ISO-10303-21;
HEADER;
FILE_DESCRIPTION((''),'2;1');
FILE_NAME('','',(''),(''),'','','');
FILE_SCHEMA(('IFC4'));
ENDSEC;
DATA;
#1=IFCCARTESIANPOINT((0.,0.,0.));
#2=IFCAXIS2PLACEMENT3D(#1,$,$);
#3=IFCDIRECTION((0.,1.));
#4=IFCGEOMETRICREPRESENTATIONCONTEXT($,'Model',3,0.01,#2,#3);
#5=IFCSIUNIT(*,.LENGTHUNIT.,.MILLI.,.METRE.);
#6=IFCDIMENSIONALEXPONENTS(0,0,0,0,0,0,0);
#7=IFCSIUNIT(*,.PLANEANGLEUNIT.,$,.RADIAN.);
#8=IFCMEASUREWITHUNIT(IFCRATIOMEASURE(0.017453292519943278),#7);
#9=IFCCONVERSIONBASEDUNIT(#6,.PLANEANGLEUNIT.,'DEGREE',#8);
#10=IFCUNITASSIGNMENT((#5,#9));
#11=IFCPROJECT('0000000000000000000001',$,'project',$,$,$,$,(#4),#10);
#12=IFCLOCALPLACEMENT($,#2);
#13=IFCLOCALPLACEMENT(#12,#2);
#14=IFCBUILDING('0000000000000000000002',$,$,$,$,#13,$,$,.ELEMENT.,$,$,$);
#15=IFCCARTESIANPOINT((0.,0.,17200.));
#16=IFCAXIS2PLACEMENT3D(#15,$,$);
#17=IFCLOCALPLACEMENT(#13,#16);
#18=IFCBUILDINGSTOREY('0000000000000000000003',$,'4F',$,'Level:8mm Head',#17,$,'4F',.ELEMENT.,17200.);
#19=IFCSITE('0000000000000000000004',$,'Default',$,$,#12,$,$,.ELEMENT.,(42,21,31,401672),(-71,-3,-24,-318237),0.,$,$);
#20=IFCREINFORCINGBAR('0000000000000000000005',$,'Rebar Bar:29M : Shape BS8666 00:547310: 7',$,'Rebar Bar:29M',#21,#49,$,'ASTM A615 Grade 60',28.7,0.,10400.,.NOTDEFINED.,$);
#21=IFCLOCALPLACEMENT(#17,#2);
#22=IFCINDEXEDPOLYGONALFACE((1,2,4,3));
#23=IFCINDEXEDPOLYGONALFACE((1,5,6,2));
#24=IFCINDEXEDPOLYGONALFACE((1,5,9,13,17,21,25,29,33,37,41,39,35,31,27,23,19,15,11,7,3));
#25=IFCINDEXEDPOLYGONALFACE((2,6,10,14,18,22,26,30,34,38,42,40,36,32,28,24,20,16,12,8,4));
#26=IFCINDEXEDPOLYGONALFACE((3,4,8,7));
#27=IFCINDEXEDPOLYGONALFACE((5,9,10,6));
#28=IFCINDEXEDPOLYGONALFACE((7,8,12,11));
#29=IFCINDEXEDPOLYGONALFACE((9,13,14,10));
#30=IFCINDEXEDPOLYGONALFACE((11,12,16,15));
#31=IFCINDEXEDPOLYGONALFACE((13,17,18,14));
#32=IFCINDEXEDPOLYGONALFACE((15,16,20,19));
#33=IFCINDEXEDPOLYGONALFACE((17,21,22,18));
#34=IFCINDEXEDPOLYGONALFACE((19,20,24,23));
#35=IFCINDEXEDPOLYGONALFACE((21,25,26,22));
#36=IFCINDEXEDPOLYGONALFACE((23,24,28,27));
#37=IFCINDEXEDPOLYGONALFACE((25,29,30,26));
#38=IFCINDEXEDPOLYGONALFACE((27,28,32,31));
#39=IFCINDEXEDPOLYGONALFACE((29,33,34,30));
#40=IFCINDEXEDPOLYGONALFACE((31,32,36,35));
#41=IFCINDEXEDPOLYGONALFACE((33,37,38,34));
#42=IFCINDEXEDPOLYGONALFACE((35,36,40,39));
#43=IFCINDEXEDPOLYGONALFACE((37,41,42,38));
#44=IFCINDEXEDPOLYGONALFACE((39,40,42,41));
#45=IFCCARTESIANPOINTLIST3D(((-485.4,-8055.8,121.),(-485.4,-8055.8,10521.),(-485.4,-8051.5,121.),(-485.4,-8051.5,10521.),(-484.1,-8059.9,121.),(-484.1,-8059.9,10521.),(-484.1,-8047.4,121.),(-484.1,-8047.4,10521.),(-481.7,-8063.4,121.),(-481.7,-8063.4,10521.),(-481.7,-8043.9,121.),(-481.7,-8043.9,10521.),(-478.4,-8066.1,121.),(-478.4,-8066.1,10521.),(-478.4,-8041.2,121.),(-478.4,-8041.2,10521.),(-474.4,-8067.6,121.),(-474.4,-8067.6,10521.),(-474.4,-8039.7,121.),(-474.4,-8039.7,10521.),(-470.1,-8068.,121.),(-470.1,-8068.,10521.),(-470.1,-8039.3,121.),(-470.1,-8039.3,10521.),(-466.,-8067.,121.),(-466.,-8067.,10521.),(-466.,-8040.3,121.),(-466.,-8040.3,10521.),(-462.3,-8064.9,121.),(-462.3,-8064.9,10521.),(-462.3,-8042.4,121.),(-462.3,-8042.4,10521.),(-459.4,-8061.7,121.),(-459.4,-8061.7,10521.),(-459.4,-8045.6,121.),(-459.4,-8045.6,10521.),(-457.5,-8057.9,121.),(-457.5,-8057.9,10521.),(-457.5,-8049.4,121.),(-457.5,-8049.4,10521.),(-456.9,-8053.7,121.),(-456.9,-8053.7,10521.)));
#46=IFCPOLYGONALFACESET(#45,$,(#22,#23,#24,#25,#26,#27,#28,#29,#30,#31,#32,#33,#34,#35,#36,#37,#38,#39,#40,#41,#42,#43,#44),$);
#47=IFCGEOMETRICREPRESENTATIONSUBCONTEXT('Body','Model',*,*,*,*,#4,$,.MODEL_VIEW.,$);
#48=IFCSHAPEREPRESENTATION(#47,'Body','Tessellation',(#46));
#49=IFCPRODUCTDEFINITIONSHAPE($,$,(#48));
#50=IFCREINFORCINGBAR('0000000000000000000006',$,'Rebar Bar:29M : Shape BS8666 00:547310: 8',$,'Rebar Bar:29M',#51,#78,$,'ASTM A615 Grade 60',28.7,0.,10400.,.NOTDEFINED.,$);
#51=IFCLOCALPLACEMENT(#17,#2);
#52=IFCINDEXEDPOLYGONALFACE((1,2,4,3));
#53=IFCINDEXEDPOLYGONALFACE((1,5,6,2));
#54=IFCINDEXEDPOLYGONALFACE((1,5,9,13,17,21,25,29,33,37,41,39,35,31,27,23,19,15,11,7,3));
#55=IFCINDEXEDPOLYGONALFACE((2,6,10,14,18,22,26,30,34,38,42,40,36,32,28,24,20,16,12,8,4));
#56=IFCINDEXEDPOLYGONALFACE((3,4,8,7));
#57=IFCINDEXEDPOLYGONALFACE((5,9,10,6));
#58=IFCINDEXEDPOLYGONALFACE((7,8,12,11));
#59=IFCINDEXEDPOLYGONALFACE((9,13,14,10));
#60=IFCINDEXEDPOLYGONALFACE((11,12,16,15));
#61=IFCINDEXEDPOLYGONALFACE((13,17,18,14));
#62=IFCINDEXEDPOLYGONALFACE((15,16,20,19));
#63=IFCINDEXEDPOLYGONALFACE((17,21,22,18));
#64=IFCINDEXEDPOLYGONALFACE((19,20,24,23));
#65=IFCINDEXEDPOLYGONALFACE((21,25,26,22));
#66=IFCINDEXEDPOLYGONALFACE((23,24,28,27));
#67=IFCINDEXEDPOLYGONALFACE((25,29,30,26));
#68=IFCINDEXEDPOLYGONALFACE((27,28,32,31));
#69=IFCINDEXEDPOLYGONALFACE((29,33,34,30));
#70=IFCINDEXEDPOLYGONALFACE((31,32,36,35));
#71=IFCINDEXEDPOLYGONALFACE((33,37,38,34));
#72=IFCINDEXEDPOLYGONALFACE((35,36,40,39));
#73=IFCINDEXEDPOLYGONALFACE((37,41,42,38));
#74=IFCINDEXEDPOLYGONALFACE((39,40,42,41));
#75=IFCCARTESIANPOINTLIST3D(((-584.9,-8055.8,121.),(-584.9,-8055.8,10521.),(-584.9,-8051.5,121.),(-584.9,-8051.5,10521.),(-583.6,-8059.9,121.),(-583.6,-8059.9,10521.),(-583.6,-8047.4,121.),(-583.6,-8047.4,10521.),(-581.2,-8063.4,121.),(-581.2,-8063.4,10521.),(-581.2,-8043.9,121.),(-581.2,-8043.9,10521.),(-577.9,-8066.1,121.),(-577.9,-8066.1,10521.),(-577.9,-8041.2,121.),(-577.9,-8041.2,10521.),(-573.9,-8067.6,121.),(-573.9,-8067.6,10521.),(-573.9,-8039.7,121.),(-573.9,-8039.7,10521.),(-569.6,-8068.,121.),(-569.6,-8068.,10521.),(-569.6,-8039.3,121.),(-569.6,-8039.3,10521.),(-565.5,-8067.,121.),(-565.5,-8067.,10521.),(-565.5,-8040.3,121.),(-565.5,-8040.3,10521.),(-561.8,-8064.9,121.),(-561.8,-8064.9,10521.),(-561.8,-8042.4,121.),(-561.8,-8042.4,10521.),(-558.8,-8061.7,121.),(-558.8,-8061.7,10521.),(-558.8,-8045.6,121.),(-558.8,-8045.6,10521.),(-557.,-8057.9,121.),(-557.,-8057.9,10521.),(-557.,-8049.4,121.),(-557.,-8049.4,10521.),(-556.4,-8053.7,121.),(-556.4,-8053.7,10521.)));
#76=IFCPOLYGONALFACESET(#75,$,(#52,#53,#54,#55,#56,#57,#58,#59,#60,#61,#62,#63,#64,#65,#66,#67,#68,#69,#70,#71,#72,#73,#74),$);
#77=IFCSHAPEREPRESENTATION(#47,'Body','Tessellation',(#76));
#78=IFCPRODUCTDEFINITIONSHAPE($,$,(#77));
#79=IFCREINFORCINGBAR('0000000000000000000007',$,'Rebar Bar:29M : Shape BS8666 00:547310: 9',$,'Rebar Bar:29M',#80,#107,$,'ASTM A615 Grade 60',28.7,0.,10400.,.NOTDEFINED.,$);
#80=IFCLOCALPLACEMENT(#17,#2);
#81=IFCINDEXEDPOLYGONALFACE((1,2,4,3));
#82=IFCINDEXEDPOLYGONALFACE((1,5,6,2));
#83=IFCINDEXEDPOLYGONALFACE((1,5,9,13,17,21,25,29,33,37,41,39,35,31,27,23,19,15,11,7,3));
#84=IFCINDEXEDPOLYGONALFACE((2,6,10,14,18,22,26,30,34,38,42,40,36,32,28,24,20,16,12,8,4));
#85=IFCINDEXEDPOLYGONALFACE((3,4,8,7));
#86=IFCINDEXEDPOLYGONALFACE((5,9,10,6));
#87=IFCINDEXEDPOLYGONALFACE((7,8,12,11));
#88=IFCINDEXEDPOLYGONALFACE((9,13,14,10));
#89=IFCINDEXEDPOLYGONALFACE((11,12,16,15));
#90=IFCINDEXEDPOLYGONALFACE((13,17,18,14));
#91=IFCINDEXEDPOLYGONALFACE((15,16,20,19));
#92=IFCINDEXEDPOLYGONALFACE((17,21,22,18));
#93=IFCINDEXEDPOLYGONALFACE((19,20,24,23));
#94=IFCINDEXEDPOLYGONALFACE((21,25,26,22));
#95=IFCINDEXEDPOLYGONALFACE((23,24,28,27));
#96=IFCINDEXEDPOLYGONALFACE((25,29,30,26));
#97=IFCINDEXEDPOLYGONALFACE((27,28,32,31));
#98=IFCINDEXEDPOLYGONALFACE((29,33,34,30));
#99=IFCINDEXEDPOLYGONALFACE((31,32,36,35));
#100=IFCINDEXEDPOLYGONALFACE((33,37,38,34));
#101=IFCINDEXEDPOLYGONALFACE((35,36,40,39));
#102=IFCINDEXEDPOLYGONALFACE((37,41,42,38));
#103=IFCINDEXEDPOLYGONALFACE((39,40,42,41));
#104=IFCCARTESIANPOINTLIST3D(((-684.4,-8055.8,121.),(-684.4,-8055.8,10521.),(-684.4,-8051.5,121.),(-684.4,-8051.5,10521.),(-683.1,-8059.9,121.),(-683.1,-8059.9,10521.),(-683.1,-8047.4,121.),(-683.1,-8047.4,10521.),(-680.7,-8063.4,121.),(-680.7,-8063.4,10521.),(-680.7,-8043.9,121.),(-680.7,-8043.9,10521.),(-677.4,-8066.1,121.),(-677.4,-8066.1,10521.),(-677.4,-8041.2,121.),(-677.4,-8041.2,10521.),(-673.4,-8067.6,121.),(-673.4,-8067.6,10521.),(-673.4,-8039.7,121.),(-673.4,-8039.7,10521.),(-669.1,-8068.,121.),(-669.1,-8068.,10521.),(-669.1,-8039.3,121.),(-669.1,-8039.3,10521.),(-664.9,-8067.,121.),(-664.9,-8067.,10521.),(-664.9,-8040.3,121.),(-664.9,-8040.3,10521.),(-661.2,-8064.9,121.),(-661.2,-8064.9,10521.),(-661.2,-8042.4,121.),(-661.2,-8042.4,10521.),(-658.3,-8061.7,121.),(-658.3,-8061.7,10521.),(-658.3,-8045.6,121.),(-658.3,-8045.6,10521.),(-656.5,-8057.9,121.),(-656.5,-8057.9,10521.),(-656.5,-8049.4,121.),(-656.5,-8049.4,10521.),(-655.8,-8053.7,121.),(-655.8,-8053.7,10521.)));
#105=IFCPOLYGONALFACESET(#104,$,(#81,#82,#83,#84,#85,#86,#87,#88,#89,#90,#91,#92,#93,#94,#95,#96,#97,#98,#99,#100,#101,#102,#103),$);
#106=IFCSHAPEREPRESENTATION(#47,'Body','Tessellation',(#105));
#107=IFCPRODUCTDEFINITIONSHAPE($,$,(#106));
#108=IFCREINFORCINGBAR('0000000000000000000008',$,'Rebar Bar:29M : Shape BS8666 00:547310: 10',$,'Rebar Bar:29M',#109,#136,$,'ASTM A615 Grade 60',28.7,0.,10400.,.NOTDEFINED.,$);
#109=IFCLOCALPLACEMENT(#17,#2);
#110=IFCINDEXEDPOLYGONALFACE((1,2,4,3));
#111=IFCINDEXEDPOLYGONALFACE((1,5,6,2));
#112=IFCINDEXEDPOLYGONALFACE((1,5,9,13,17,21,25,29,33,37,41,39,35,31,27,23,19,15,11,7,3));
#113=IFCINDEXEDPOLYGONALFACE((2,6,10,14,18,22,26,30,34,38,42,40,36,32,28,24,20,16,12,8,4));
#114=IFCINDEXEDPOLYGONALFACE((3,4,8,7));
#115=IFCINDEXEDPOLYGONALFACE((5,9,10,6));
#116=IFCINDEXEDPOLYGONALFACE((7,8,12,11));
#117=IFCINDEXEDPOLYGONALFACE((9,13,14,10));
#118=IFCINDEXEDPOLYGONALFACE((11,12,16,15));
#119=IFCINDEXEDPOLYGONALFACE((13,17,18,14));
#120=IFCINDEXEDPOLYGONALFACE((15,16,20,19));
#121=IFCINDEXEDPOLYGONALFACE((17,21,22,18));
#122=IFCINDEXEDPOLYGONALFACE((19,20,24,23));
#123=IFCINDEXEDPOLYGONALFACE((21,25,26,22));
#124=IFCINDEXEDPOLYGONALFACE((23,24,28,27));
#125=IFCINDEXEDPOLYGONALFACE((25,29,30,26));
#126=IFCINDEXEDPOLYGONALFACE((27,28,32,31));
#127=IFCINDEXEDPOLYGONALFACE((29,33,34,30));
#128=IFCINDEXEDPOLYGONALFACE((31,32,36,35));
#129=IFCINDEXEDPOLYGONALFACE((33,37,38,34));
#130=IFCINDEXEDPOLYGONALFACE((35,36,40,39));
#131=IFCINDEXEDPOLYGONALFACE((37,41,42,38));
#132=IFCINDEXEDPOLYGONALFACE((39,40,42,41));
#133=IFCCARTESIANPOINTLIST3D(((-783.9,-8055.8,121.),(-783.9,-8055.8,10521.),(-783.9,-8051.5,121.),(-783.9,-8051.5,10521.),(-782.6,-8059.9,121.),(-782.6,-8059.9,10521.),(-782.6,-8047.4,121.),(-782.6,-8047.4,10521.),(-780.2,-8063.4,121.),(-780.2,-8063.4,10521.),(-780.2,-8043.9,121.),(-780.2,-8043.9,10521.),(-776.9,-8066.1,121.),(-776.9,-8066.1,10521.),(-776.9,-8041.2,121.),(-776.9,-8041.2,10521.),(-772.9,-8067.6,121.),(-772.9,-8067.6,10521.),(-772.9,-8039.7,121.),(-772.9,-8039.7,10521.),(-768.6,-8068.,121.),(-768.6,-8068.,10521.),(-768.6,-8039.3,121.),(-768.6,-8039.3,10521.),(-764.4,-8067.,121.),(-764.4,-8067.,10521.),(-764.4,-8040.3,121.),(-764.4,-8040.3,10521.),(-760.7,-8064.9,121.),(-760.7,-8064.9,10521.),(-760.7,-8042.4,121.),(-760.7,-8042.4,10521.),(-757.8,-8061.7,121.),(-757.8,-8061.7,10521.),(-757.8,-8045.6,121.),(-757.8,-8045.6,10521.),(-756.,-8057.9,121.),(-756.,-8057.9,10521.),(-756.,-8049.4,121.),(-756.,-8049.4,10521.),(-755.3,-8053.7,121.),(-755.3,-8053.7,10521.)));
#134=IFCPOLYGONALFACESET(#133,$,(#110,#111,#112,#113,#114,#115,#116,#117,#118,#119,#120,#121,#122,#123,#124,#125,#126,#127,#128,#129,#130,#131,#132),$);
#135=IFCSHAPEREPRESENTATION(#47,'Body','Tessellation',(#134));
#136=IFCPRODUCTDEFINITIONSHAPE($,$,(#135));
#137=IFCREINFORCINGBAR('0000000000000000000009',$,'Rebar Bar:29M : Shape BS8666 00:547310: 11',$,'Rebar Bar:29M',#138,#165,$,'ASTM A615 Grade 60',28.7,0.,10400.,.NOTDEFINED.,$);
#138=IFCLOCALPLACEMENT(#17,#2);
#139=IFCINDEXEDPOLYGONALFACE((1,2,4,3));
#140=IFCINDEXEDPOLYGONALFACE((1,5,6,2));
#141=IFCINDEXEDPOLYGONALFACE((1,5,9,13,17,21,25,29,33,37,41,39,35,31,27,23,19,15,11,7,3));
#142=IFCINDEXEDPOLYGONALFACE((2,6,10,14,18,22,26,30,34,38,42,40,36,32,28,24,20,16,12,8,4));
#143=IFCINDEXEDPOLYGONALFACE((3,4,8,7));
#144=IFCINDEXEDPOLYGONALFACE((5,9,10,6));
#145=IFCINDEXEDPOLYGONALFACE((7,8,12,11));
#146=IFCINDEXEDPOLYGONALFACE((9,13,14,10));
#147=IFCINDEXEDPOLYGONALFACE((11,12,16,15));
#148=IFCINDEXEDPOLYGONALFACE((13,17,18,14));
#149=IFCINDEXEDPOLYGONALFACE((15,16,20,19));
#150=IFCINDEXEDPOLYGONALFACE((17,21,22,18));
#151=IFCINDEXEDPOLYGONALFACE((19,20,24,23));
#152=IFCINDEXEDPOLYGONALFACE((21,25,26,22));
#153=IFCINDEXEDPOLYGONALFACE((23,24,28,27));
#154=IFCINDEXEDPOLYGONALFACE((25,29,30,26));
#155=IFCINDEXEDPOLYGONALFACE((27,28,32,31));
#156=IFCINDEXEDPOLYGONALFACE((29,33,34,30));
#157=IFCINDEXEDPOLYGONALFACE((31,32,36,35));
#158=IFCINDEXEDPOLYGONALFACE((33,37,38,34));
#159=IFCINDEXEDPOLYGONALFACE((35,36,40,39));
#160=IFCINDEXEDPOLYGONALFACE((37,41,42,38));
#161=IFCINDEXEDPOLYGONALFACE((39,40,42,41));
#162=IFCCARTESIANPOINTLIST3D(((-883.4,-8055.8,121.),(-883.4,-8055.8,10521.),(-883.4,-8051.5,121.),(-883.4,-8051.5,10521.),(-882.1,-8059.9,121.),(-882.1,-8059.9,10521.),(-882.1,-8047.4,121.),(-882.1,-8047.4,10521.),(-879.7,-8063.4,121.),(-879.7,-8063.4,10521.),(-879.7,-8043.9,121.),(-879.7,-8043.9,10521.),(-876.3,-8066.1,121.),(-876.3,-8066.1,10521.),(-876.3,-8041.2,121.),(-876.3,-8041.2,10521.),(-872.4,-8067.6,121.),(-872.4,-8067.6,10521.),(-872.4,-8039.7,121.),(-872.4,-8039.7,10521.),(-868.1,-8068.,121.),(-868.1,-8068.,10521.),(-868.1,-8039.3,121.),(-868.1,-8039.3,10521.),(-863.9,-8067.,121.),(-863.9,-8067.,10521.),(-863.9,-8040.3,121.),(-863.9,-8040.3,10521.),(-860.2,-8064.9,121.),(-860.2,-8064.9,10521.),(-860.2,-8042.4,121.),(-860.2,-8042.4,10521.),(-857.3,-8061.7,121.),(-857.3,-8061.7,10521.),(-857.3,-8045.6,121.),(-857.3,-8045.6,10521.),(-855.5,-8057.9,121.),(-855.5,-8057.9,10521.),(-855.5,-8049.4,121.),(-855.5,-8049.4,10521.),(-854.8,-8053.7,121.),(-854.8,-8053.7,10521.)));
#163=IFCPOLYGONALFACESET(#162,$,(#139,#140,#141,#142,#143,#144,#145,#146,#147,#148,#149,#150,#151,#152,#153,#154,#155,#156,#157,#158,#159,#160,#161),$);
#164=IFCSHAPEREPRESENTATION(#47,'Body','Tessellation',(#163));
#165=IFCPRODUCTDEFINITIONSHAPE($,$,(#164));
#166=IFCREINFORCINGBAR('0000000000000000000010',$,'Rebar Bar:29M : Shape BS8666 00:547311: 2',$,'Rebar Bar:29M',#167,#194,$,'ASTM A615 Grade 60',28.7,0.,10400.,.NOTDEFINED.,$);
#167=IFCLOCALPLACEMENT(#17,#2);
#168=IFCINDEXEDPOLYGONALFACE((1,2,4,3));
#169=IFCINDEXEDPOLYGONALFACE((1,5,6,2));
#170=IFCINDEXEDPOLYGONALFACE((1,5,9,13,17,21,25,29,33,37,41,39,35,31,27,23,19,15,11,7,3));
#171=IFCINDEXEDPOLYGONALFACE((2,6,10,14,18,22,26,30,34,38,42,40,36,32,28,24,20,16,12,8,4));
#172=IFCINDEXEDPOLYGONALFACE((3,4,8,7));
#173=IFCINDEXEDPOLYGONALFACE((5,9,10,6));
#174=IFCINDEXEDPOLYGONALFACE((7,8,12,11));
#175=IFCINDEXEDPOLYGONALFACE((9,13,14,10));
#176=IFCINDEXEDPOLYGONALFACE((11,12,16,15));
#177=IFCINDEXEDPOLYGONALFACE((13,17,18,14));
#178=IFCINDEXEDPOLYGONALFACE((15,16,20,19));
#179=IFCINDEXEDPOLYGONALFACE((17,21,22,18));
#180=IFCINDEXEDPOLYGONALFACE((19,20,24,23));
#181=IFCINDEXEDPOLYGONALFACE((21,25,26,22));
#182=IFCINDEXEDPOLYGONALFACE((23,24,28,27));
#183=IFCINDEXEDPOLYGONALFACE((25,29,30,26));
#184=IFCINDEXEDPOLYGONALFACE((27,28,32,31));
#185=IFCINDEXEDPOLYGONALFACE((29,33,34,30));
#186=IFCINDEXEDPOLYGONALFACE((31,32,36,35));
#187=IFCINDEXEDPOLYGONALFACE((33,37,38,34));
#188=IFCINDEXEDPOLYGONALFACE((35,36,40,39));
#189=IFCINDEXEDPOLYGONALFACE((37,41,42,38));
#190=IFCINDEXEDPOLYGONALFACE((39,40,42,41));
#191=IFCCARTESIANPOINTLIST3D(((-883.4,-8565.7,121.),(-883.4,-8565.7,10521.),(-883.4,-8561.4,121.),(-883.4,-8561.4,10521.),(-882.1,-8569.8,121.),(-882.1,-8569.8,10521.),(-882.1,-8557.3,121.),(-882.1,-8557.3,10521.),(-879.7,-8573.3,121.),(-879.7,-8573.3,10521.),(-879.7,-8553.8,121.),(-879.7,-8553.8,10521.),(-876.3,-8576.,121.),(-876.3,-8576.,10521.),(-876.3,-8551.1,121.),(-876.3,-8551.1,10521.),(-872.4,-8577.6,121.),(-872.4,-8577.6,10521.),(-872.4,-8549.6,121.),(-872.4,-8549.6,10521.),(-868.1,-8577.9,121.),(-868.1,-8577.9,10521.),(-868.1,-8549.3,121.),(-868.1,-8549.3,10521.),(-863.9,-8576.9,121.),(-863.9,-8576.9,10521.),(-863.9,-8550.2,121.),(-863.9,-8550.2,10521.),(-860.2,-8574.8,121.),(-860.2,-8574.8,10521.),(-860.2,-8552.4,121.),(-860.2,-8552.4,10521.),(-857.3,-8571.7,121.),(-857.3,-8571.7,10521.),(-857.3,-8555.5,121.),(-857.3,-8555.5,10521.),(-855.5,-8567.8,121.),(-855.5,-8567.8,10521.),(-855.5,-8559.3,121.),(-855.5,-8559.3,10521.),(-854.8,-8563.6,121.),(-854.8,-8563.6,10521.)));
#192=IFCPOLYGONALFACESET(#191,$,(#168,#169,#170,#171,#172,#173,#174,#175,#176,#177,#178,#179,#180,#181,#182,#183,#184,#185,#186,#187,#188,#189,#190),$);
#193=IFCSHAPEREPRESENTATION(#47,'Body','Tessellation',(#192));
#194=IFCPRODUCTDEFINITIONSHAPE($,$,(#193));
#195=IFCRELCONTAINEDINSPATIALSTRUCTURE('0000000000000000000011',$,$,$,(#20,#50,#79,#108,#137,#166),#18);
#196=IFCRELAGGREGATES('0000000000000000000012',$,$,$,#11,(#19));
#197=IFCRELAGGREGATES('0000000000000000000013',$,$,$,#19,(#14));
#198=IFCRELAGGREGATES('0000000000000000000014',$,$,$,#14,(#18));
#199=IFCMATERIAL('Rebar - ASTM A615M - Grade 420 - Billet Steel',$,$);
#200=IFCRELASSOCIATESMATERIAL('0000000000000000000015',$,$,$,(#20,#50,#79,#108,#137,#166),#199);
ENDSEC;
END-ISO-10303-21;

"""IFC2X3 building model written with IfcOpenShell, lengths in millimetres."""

from ifc_helpers import new_model, entity, si_unit, converted_unit, direction, frame, origin, place, context, subcontext, project, spatial, material, element, save


model = new_model("IFC2X3")

# Units and contexts
model_context = context("Model", 3, precision=0.01, world=origin(), true_north=direction((0.0, 1.0)))
body_context = subcontext(model_context, "Body", "Model", "MODEL_VIEW")
ifc_project = project(units=[si_unit("LENGTHUNIT", "METRE", prefix="MILLI"), converted_unit("PLANEANGLEUNIT", "DEGREE", entity("IfcRatioMeasure", 0.017453292519943278), si_unit("PLANEANGLEUNIT", "RADIAN"), dimensions=[0, 0, 0, 0, 0, 0, 0])], contexts=[model_context])

# Site, building, storey
site_placement = place(None, origin())
site = spatial("IfcSite", under=ifc_project, at=site_placement, Name="Default", CompositionType="ELEMENT", RefLatitude=(42, 21, 31, 401672), RefLongitude=(-71, -3, -24, -318237), RefElevation=0.0)
building_placement = place(site_placement, origin())
building = spatial("IfcBuilding", under=site, at=building_placement, CompositionType="ELEMENT")
storey_placement = place(building_placement, frame((0.0, 0.0, 17200.0)))
storey = spatial("IfcBuildingStorey", under=building, at=storey_placement, Name="4F", ObjectType="Level:8mm Head", LongName="4F", CompositionType="ELEMENT", Elevation=17200.0)

# Reinforcing bars
ifc_material_1 = material(Name="Rebar - ASTM A615M - Grade 420 - Billet Steel")
reinforcing_bar_1_placement = place(storey_placement, origin())
element("IfcReinforcingBar", 1, at=reinforcing_bar_1_placement, inside=storey, material=ifc_material_1, Name="Rebar Bar:29M : Shape BS8666 00:547310: 7", SteelGrade="ASTM A615 Grade 60", ObjectType="Rebar Bar:29M", BarLength=10400.0, BarRole="NOTDEFINED", CrossSectionArea=0.0, NominalDiameter=28.7, context=body_context, shape_type="AdvancedSweptSolid", body=[
    entity("IfcSweptDiskSolid", entity("IfcCompositeCurve", [entity("IfcCompositeCurveSegment", "CONTINUOUS", True, entity("IfcPolyline", [entity("IfcCartesianPoint", [-471.2, -8053.7, 121.0]), entity("IfcCartesianPoint", [-471.2, -8053.7, 10521.0])]))], False), 14.3, None, 0.0, 1.0),
])
reinforcing_bar_2_placement = place(storey_placement, origin())
element("IfcReinforcingBar", 2, at=reinforcing_bar_2_placement, inside=storey, material=ifc_material_1, Name="Rebar Bar:29M : Shape BS8666 00:547310: 8", SteelGrade="ASTM A615 Grade 60", ObjectType="Rebar Bar:29M", BarLength=10400.0, BarRole="NOTDEFINED", CrossSectionArea=0.0, NominalDiameter=28.7, context=body_context, shape_type="AdvancedSweptSolid", body=[
    entity("IfcSweptDiskSolid", entity("IfcCompositeCurve", [entity("IfcCompositeCurveSegment", "CONTINUOUS", True, entity("IfcPolyline", [entity("IfcCartesianPoint", [-570.7, -8053.7, 121.0]), entity("IfcCartesianPoint", [-570.7, -8053.7, 10521.0])]))], False), 14.3, None, 0.0, 1.0),
])
reinforcing_bar_3_placement = place(storey_placement, origin())
element("IfcReinforcingBar", 3, at=reinforcing_bar_3_placement, inside=storey, material=ifc_material_1, Name="Rebar Bar:29M : Shape BS8666 00:547310: 9", SteelGrade="ASTM A615 Grade 60", ObjectType="Rebar Bar:29M", BarLength=10400.0, BarRole="NOTDEFINED", CrossSectionArea=0.0, NominalDiameter=28.7, context=body_context, shape_type="AdvancedSweptSolid", body=[
    entity("IfcSweptDiskSolid", entity("IfcCompositeCurve", [entity("IfcCompositeCurveSegment", "CONTINUOUS", True, entity("IfcPolyline", [entity("IfcCartesianPoint", [-670.2, -8053.7, 121.0]), entity("IfcCartesianPoint", [-670.2, -8053.7, 10521.0])]))], False), 14.3, None, 0.0, 1.0),
])
reinforcing_bar_4_placement = place(storey_placement, origin())
element("IfcReinforcingBar", 4, at=reinforcing_bar_4_placement, inside=storey, material=ifc_material_1, Name="Rebar Bar:29M : Shape BS8666 00:547310: 10", SteelGrade="ASTM A615 Grade 60", ObjectType="Rebar Bar:29M", BarLength=10400.0, BarRole="NOTDEFINED", CrossSectionArea=0.0, NominalDiameter=28.7, context=body_context, shape_type="AdvancedSweptSolid", body=[
    entity("IfcSweptDiskSolid", entity("IfcCompositeCurve", [entity("IfcCompositeCurveSegment", "CONTINUOUS", True, entity("IfcPolyline", [entity("IfcCartesianPoint", [-769.7, -8053.7, 121.0]), entity("IfcCartesianPoint", [-769.7, -8053.7, 10521.0])]))], False), 14.3, None, 0.0, 1.0),
])
reinforcing_bar_5_placement = place(storey_placement, origin())
element("IfcReinforcingBar", 5, at=reinforcing_bar_5_placement, inside=storey, material=ifc_material_1, Name="Rebar Bar:29M : Shape BS8666 00:547310: 11", SteelGrade="ASTM A615 Grade 60", ObjectType="Rebar Bar:29M", BarLength=10400.0, BarRole="NOTDEFINED", CrossSectionArea=0.0, NominalDiameter=28.7, context=body_context, shape_type="AdvancedSweptSolid", body=[
    entity("IfcSweptDiskSolid", entity("IfcCompositeCurve", [entity("IfcCompositeCurveSegment", "CONTINUOUS", True, entity("IfcPolyline", [entity("IfcCartesianPoint", [-869.2, -8053.7, 121.0]), entity("IfcCartesianPoint", [-869.2, -8053.7, 10521.0])]))], False), 14.3, None, 0.0, 1.0),
])
reinforcing_bar_6_placement = place(storey_placement, origin())
element("IfcReinforcingBar", 6, at=reinforcing_bar_6_placement, inside=storey, material=ifc_material_1, Name="Rebar Bar:29M : Shape BS8666 00:547311: 2", SteelGrade="ASTM A615 Grade 60", ObjectType="Rebar Bar:29M", BarLength=10400.0, BarRole="NOTDEFINED", CrossSectionArea=0.0, NominalDiameter=28.7, context=body_context, shape_type="AdvancedSweptSolid", body=[
    entity("IfcSweptDiskSolid", entity("IfcCompositeCurve", [entity("IfcCompositeCurveSegment", "CONTINUOUS", True, entity("IfcPolyline", [entity("IfcCartesianPoint", [-869.2, -8563.6, 121.0]), entity("IfcCartesianPoint", [-869.2, -8563.6, 10521.0])]))], False), 14.3, None, 0.0, 1.0),
])

save(model, "model.ifc")
